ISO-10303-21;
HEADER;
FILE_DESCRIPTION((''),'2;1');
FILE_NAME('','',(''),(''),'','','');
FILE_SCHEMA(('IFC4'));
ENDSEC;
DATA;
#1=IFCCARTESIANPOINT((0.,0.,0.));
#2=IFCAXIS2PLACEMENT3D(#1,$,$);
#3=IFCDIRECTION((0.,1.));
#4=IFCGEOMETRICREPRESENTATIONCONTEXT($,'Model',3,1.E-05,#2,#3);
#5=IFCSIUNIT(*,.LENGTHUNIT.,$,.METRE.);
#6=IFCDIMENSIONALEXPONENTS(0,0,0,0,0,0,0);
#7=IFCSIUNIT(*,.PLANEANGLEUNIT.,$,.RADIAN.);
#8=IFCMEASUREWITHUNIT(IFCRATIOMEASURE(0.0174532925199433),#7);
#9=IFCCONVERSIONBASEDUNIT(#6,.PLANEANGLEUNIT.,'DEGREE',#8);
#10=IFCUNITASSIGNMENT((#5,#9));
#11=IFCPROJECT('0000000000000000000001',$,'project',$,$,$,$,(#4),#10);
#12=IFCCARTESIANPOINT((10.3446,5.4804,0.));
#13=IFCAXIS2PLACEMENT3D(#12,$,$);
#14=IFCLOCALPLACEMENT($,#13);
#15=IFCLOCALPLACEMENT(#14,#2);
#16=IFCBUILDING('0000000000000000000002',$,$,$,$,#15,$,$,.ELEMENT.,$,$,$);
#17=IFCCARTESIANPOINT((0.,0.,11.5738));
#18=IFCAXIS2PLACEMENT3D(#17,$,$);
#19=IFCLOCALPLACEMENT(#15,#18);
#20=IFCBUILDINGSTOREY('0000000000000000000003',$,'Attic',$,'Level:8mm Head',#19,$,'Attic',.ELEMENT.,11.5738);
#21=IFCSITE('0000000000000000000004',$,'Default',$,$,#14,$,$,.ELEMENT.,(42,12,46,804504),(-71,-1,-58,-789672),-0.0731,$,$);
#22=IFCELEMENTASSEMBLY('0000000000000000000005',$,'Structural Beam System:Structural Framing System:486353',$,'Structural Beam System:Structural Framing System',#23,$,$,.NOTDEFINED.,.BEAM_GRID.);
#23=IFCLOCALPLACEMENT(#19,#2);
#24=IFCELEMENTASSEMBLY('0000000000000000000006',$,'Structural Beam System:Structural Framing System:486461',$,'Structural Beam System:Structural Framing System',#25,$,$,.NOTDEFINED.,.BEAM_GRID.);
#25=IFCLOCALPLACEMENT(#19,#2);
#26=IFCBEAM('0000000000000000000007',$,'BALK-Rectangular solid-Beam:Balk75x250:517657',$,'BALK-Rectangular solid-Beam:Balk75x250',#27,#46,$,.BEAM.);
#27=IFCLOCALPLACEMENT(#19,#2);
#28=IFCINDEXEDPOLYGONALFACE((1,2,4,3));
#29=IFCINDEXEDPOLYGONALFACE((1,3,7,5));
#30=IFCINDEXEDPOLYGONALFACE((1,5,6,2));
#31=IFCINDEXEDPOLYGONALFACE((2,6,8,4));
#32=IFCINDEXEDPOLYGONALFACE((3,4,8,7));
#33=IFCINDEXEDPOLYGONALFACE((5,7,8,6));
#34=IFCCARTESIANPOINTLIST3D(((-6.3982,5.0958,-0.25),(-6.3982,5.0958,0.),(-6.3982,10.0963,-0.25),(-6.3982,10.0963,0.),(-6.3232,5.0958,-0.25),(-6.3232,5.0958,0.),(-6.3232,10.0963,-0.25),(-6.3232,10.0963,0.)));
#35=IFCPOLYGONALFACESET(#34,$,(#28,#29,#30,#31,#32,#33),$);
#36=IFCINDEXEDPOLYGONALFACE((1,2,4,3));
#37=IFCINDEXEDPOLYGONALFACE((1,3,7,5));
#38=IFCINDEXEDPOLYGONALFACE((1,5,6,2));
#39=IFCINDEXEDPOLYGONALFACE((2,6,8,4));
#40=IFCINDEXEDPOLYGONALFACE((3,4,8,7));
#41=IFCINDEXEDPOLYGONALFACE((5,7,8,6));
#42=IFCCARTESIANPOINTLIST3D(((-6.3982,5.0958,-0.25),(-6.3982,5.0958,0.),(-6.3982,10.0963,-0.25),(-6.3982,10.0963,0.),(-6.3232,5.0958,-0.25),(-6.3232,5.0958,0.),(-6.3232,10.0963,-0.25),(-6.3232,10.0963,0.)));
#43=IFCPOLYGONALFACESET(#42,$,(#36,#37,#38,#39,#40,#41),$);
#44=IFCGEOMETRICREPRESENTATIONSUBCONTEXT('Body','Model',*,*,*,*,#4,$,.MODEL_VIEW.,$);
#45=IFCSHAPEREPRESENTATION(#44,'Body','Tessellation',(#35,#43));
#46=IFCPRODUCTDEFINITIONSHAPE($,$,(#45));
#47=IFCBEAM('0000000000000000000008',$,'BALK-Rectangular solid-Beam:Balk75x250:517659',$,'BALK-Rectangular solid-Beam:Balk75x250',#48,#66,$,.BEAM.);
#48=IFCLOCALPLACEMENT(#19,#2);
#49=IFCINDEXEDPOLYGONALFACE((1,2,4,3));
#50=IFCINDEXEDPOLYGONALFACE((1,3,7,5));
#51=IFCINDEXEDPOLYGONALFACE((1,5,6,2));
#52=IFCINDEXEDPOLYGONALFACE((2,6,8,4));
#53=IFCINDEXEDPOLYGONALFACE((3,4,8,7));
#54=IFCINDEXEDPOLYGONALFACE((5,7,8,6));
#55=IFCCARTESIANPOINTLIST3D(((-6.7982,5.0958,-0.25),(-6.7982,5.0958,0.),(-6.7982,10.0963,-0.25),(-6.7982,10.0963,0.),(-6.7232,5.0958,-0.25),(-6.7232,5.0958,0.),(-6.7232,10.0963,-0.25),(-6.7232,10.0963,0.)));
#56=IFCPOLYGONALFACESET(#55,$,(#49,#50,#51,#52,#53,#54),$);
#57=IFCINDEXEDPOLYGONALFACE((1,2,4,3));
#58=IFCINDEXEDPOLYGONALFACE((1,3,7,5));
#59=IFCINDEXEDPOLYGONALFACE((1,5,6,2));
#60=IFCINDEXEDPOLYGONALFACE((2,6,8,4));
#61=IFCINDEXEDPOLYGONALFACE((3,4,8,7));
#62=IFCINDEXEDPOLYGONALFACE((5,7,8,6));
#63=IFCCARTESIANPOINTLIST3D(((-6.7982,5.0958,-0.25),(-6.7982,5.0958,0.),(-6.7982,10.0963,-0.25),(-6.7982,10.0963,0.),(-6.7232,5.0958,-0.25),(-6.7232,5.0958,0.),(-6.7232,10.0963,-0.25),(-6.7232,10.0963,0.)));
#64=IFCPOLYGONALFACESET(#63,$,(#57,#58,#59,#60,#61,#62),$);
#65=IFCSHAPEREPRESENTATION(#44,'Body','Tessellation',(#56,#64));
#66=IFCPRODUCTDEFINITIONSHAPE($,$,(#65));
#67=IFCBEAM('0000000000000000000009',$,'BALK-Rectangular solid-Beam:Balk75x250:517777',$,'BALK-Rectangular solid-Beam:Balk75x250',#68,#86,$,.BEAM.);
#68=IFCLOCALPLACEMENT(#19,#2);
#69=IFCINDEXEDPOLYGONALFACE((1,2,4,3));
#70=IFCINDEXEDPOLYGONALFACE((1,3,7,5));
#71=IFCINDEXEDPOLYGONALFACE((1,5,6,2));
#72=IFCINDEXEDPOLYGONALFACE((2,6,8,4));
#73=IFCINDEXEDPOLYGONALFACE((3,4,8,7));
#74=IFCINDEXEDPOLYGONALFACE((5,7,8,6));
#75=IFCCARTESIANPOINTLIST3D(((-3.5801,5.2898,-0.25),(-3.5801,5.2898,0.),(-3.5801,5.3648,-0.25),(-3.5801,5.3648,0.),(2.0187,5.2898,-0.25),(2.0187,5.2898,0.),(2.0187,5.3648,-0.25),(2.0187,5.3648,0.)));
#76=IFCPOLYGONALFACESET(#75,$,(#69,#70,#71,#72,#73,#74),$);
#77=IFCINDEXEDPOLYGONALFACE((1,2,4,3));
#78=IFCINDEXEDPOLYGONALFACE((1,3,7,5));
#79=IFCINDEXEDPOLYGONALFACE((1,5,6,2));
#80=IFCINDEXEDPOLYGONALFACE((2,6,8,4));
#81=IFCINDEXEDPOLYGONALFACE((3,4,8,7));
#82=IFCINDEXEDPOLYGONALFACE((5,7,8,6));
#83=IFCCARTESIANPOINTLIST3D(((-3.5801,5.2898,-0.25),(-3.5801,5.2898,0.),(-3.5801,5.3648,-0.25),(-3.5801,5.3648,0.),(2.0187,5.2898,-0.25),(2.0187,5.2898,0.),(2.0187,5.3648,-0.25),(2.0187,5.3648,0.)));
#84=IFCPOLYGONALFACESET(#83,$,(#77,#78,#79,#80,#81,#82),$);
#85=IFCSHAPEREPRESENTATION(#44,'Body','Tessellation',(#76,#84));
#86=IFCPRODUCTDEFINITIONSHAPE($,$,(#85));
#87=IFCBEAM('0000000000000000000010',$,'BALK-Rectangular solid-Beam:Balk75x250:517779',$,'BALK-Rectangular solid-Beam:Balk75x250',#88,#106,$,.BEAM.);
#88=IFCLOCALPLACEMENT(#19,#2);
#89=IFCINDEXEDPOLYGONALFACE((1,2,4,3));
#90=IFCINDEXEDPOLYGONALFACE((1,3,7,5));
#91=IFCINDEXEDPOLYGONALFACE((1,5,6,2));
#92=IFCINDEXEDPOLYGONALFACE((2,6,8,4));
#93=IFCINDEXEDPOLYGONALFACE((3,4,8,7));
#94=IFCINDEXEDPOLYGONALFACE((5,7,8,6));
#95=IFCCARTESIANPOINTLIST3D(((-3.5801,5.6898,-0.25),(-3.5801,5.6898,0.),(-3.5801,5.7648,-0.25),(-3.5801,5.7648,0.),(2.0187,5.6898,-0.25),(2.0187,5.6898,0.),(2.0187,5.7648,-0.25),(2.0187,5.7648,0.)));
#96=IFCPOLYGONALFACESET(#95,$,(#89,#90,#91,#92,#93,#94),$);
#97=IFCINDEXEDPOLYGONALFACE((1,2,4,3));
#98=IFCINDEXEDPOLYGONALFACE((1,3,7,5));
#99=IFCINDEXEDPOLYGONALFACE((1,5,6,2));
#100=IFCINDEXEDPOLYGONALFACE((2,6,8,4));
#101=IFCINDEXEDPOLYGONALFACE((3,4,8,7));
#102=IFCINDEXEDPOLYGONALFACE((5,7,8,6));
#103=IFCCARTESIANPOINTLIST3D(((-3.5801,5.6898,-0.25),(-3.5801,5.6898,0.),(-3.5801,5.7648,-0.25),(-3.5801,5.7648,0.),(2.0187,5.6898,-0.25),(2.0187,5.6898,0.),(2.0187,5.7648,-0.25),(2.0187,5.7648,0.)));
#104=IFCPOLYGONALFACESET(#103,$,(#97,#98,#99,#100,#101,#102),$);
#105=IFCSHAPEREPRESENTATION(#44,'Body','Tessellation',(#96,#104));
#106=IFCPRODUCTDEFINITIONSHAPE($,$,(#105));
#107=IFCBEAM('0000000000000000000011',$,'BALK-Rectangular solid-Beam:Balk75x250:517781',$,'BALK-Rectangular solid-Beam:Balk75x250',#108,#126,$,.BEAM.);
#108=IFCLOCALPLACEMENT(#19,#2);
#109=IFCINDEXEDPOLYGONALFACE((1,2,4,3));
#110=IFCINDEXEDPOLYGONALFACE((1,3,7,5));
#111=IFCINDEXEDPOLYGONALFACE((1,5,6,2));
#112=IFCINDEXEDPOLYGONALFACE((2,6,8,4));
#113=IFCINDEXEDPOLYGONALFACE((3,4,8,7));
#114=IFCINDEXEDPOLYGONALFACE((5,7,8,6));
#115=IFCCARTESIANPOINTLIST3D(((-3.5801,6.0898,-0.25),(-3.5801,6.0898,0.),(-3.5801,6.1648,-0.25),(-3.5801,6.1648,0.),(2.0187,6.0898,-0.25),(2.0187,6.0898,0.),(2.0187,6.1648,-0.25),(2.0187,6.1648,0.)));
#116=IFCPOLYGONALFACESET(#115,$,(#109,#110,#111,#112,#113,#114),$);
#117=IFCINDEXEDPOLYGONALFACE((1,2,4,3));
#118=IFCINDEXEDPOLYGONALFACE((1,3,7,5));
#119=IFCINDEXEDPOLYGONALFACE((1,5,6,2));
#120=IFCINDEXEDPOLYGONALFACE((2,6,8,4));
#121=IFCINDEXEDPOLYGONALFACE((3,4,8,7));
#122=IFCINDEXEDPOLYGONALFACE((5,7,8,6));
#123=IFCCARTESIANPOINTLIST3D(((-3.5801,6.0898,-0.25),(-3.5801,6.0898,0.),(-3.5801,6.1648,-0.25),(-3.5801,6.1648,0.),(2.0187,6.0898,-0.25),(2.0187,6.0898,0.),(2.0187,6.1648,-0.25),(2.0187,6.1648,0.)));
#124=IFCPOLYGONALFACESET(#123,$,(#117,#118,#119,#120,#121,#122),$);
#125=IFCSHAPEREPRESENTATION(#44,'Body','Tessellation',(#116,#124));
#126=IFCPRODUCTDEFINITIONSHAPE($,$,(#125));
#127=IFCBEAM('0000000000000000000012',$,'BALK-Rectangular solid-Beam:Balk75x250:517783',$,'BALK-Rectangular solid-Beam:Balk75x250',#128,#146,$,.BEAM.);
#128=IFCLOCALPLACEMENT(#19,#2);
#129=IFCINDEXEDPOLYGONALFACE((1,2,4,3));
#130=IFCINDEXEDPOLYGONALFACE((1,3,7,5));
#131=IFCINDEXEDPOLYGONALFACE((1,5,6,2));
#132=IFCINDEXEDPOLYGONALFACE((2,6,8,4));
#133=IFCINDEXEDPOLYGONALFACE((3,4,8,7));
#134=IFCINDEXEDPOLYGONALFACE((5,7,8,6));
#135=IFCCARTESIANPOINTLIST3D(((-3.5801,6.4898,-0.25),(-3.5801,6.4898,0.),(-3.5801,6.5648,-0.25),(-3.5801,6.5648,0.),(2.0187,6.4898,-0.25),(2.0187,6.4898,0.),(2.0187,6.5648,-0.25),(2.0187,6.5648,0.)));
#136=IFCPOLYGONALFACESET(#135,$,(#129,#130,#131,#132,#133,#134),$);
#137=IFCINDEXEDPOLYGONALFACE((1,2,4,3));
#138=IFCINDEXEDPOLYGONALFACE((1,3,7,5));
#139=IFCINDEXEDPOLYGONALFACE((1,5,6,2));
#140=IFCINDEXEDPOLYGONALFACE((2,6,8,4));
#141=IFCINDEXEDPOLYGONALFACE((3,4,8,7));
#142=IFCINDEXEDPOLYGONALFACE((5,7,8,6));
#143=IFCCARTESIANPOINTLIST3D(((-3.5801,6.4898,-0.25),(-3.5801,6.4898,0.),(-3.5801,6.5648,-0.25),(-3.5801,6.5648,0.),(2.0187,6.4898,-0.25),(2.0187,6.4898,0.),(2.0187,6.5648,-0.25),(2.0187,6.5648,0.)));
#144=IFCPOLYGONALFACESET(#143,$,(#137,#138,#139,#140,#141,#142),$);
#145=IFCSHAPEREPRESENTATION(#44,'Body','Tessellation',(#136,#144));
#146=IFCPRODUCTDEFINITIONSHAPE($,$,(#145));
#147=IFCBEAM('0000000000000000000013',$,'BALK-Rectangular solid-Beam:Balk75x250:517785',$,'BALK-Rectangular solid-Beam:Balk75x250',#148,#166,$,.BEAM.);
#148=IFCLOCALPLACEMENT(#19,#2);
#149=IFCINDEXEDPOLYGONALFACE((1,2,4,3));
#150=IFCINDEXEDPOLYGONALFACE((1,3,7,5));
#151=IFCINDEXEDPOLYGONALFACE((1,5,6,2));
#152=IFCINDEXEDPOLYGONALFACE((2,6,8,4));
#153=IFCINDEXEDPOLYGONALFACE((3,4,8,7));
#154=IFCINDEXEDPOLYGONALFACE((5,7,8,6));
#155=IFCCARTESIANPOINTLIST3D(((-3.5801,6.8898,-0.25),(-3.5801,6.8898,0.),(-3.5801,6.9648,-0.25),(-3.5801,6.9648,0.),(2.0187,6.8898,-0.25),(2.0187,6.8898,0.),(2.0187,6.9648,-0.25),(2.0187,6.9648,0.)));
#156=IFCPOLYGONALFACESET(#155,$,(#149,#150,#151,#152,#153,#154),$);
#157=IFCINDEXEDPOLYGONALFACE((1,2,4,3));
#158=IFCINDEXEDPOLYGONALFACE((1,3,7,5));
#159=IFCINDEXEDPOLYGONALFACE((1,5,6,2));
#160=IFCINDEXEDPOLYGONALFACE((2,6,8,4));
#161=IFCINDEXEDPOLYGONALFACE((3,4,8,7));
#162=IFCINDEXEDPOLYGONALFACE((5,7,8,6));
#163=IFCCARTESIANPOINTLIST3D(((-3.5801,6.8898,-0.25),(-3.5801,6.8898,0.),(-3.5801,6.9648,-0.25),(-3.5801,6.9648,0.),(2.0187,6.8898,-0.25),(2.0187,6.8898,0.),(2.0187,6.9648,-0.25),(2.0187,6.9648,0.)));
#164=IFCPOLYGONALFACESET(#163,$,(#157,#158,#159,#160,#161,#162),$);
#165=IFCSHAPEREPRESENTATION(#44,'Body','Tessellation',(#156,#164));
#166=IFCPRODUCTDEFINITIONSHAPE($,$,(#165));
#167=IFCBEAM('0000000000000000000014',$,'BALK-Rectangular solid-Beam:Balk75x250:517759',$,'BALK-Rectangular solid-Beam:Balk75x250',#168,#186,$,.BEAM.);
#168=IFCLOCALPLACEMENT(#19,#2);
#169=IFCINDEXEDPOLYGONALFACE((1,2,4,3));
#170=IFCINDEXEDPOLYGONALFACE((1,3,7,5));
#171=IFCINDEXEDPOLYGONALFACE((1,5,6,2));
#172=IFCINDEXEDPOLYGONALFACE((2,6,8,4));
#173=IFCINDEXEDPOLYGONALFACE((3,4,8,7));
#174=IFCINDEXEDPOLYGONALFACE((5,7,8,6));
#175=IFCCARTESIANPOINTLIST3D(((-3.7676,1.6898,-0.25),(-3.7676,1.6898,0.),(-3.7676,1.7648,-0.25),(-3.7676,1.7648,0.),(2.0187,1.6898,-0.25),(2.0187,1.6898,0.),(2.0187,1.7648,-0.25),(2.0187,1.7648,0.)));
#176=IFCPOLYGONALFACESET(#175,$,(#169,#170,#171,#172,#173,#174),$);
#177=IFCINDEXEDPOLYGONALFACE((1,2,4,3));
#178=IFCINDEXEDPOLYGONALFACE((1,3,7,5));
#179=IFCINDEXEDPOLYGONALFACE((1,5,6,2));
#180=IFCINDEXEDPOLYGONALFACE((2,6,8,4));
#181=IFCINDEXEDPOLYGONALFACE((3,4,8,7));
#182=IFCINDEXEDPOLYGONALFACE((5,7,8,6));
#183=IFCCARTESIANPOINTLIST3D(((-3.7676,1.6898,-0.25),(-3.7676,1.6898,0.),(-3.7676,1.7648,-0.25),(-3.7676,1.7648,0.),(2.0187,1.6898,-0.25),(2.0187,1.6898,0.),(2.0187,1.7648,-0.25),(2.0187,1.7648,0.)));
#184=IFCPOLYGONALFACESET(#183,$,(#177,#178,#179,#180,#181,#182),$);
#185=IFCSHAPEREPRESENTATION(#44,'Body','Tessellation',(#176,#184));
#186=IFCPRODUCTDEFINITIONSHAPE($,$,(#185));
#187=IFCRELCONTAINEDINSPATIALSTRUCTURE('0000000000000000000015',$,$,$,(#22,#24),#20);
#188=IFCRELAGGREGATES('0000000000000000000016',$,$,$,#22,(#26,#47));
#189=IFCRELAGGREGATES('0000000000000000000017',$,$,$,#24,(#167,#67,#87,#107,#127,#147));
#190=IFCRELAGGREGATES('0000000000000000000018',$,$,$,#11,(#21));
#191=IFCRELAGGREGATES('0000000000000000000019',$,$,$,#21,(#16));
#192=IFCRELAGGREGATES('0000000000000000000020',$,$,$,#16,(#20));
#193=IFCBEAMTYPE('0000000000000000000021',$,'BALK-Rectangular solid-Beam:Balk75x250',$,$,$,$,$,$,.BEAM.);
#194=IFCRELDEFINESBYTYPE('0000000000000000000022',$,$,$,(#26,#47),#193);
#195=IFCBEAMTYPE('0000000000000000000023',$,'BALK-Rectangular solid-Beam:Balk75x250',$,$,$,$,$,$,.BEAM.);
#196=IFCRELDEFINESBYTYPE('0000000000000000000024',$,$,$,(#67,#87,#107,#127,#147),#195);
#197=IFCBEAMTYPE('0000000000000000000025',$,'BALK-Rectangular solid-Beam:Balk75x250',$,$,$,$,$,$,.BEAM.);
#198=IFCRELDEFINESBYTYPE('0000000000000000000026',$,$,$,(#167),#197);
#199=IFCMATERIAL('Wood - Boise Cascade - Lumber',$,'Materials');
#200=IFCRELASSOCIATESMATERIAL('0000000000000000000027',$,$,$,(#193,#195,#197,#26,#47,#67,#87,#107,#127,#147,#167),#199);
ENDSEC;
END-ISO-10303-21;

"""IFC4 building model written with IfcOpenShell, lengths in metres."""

from ifc_helpers import new_model, entity, si_unit, converted_unit, direction, frame, frame_2d, origin, origin_2d_with_axis, place, context, subcontext, project, spatial, rectangle, extrude, source, transform, mapped, material, material_profile, profile_set, profile_usage, type_object, type_shapes, element, aggregate, save


model = new_model("IFC4")

# Units and contexts
model_context = context("Model", 3, precision=1e-05, world=origin(), true_north=direction((0.0, 1.0)))
body_context = subcontext(model_context, "Body", "Model", "MODEL_VIEW")
ifc_project = project(units=[si_unit("LENGTHUNIT", "METRE"), converted_unit("PLANEANGLEUNIT", "DEGREE", entity("IfcRatioMeasure", 0.0174532925199433), si_unit("PLANEANGLEUNIT", "RADIAN"), dimensions=[0, 0, 0, 0, 0, 0, 0])], contexts=[model_context])

# Site, building, storey
site_placement = place(None, frame((10.3446, 5.4804, 0.0)))
site = spatial("IfcSite", under=ifc_project, at=site_placement, Name="Default", CompositionType="ELEMENT", RefLatitude=(42, 12, 46, 804504), RefLongitude=(-71, -1, -58, -789672), RefElevation=-0.0731)
building_placement = place(site_placement, origin())
building = spatial("IfcBuilding", under=site, at=building_placement, CompositionType="ELEMENT")
storey_placement = place(building_placement, frame((0.0, 0.0, 11.5738)))
storey = spatial("IfcBuildingStorey", under=building, at=storey_placement, Name="Attic", ObjectType="Level:8mm Head", LongName="Attic", CompositionType="ELEMENT", Elevation=11.5738)

# Element assemblies
assembly_1_placement = place(storey_placement, origin())
assembly_1 = element("IfcElementAssembly", 1, at=assembly_1_placement, inside=storey, Name="Structural Beam System:Structural Framing System:486353", ObjectType="Structural Beam System:Structural Framing System", AssemblyPlace="NOTDEFINED", PredefinedType="BEAM_GRID")
ifc_material = material(Name="Wood - Boise Cascade - Lumber", Category="Materials")
ifc_material_profile = material_profile(ifc_material, rectangle(XDim=0.25, YDim=0.075, at=frame_2d((0.0, 0.0), x_axis=(1.0, 0.0))), Name="Balk75x250")
ifc_profile_set = profile_set([ifc_material_profile], Name="Balk75x250")
assembly_2_placement = place(storey_placement, origin())
assembly_2 = element("IfcElementAssembly", 2, at=assembly_2_placement, inside=storey, Name="Structural Beam System:Structural Framing System:486461", ObjectType="Structural Beam System:Structural Framing System", AssemblyPlace="NOTDEFINED", PredefinedType="BEAM_GRID")

# Beams
beam_type_1 = type_object("IfcBeamType", Name="BALK-Rectangular solid-Beam:Balk75x250", PredefinedType="BEAM", material=ifc_profile_set)
shared_shape_1 = source(origin(), body_context, "Body", "SweptSolid", [
    extrude(rectangle(XDim=0.25, YDim=0.075, at=origin_2d_with_axis()), frame((-2.394, 0.0, 0.0), z_axis=(1.0, 0.0, 0.0), x_axis=(0.0, 0.0, -1.0)), (0.0, 0.0, 1.0), 5.0005),
    extrude(rectangle(XDim=0.25, YDim=0.075, at=origin_2d_with_axis()), frame((-2.394, 0.0, 0.0), z_axis=(1.0, 0.0, 0.0), x_axis=(0.0, 0.0, -1.0)), (0.0, 0.0, 1.0), 5.0005),
])
type_shapes(beam_type_1, [shared_shape_1])
ifc_profile_usage_1 = profile_usage(ifc_profile_set, cardinal=8)
beam_1_placement = place(assembly_1_placement, frame((-6.3607, 7.7023, -0.125), z_axis=(0.0, 0.0, 1.0), x_axis=(0.0, -1.0, 0.0)))
beam_1 = element("IfcBeam", 3, at=beam_1_placement, type_object=beam_type_1, material=ifc_profile_usage_1, Name="BALK-Rectangular solid-Beam:Balk75x250:517657", ObjectType="BALK-Rectangular solid-Beam:Balk75x250", PredefinedType="BEAM", context=body_context, shape_type="MappedRepresentation", body=[
    mapped(shared_shape_1, transform((0.0, 0.0, 0.0), scale=1.0)),
])
ifc_profile_usage_2 = profile_usage(ifc_profile_set, cardinal=8)
beam_2_placement = place(assembly_1_placement, frame((-6.7607, 7.7023, -0.125), z_axis=(0.0, 0.0, 1.0), x_axis=(0.0, -1.0, 0.0)))
beam_2 = element("IfcBeam", 4, at=beam_2_placement, type_object=beam_type_1, material=ifc_profile_usage_2, Name="BALK-Rectangular solid-Beam:Balk75x250:517659", ObjectType="BALK-Rectangular solid-Beam:Balk75x250", PredefinedType="BEAM", context=body_context, shape_type="MappedRepresentation", body=[
    mapped(shared_shape_1, transform((0.0, 0.0, 0.0), scale=1.0)),
])
aggregate(assembly_1, [beam_1, beam_2])
ifc_profile_usage_3 = profile_usage(ifc_profile_set, cardinal=8)
beam_type_2 = type_object("IfcBeamType", Name="BALK-Rectangular solid-Beam:Balk75x250", PredefinedType="BEAM", material=ifc_profile_set)
shared_shape_2 = source(origin(), body_context, "Body", "SweptSolid", [
    extrude(rectangle(XDim=0.25, YDim=0.075, at=origin_2d_with_axis()), frame((-2.7994, 0.0, 0.0), z_axis=(1.0, 0.0, 0.0), x_axis=(0.0, 0.0, -1.0)), (0.0, 0.0, 1.0), 5.5988),
    extrude(rectangle(XDim=0.25, YDim=0.075, at=origin_2d_with_axis()), frame((-2.7994, 0.0, 0.0), z_axis=(1.0, 0.0, 0.0), x_axis=(0.0, 0.0, -1.0)), (0.0, 0.0, 1.0), 5.5988),
])
type_shapes(beam_type_2, [shared_shape_2])
beam_3_placement = place(assembly_2_placement, frame((-0.7807, 5.3273, -0.125), z_axis=(0.0, 0.0, 1.0), x_axis=(-1.0, 0.0, 0.0)))
beam_3 = element("IfcBeam", 5, at=beam_3_placement, type_object=beam_type_2, material=ifc_profile_usage_3, Name="BALK-Rectangular solid-Beam:Balk75x250:517777", ObjectType="BALK-Rectangular solid-Beam:Balk75x250", PredefinedType="BEAM", context=body_context, shape_type="MappedRepresentation", body=[
    mapped(shared_shape_2, transform((0.0, 0.0, 0.0), scale=1.0)),
])
ifc_profile_usage_4 = profile_usage(ifc_profile_set, cardinal=8)
beam_4_placement = place(assembly_2_placement, frame((-0.7807, 5.7273, -0.125), z_axis=(0.0, 0.0, 1.0), x_axis=(-1.0, 0.0, 0.0)))
beam_4 = element("IfcBeam", 6, at=beam_4_placement, type_object=beam_type_2, material=ifc_profile_usage_4, Name="BALK-Rectangular solid-Beam:Balk75x250:517779", ObjectType="BALK-Rectangular solid-Beam:Balk75x250", PredefinedType="BEAM", context=body_context, shape_type="MappedRepresentation", body=[
    mapped(shared_shape_2, transform((0.0, 0.0, 0.0), scale=1.0)),
])
ifc_profile_usage_5 = profile_usage(ifc_profile_set, cardinal=8)
beam_5_placement = place(assembly_2_placement, frame((-0.7807, 6.1273, -0.125), z_axis=(0.0, 0.0, 1.0), x_axis=(-1.0, 0.0, 0.0)))
beam_5 = element("IfcBeam", 7, at=beam_5_placement, type_object=beam_type_2, material=ifc_profile_usage_5, Name="BALK-Rectangular solid-Beam:Balk75x250:517781", ObjectType="BALK-Rectangular solid-Beam:Balk75x250", PredefinedType="BEAM", context=body_context, shape_type="MappedRepresentation", body=[
    mapped(shared_shape_2, transform((0.0, 0.0, 0.0), scale=1.0)),
])
ifc_profile_usage_6 = profile_usage(ifc_profile_set, cardinal=8)
beam_6_placement = place(assembly_2_placement, frame((-0.7807, 6.5273, -0.125), z_axis=(0.0, 0.0, 1.0), x_axis=(-1.0, 0.0, 0.0)))
beam_6 = element("IfcBeam", 8, at=beam_6_placement, type_object=beam_type_2, material=ifc_profile_usage_6, Name="BALK-Rectangular solid-Beam:Balk75x250:517783", ObjectType="BALK-Rectangular solid-Beam:Balk75x250", PredefinedType="BEAM", context=body_context, shape_type="MappedRepresentation", body=[
    mapped(shared_shape_2, transform((0.0, 0.0, 0.0), scale=1.0)),
])
ifc_profile_usage_7 = profile_usage(ifc_profile_set, cardinal=8)
beam_7_placement = place(assembly_2_placement, frame((-0.7807, 6.9273, -0.125), z_axis=(0.0, 0.0, 1.0), x_axis=(-1.0, 0.0, 0.0)))
beam_7 = element("IfcBeam", 9, at=beam_7_placement, type_object=beam_type_2, material=ifc_profile_usage_7, Name="BALK-Rectangular solid-Beam:Balk75x250:517785", ObjectType="BALK-Rectangular solid-Beam:Balk75x250", PredefinedType="BEAM", context=body_context, shape_type="MappedRepresentation", body=[
    mapped(shared_shape_2, transform((0.0, 0.0, 0.0), scale=1.0)),
])
ifc_profile_usage_8 = profile_usage(ifc_profile_set, cardinal=8)
beam_type_3 = type_object("IfcBeamType", Name="BALK-Rectangular solid-Beam:Balk75x250", PredefinedType="BEAM", material=ifc_profile_set)
shared_shape_3 = source(origin(), body_context, "Body", "SweptSolid", [
    extrude(rectangle(XDim=0.25, YDim=0.075, at=origin_2d_with_axis()), frame((-2.7994, 0.0, 0.0), z_axis=(1.0, 0.0, 0.0), x_axis=(0.0, 0.0, -1.0)), (0.0, 0.0, 1.0), 5.7863),
    extrude(rectangle(XDim=0.25, YDim=0.075, at=origin_2d_with_axis()), frame((-2.7994, 0.0, 0.0), z_axis=(1.0, 0.0, 0.0), x_axis=(0.0, 0.0, -1.0)), (0.0, 0.0, 1.0), 5.7863),
])
type_shapes(beam_type_3, [shared_shape_3])
beam_8_placement = place(assembly_2_placement, frame((-0.7807, 1.7273, -0.125), z_axis=(0.0, 0.0, 1.0), x_axis=(-1.0, 0.0, 0.0)))
beam_8 = element("IfcBeam", 10, at=beam_8_placement, type_object=beam_type_3, material=ifc_profile_usage_8, Name="BALK-Rectangular solid-Beam:Balk75x250:517759", ObjectType="BALK-Rectangular solid-Beam:Balk75x250", PredefinedType="BEAM", context=body_context, shape_type="MappedRepresentation", body=[
    mapped(shared_shape_3, transform((0.0, 0.0, 0.0), scale=1.0)),
])
aggregate(assembly_2, [beam_8, beam_3, beam_4, beam_5, beam_6, beam_7])

save(model, "model.ifc")
